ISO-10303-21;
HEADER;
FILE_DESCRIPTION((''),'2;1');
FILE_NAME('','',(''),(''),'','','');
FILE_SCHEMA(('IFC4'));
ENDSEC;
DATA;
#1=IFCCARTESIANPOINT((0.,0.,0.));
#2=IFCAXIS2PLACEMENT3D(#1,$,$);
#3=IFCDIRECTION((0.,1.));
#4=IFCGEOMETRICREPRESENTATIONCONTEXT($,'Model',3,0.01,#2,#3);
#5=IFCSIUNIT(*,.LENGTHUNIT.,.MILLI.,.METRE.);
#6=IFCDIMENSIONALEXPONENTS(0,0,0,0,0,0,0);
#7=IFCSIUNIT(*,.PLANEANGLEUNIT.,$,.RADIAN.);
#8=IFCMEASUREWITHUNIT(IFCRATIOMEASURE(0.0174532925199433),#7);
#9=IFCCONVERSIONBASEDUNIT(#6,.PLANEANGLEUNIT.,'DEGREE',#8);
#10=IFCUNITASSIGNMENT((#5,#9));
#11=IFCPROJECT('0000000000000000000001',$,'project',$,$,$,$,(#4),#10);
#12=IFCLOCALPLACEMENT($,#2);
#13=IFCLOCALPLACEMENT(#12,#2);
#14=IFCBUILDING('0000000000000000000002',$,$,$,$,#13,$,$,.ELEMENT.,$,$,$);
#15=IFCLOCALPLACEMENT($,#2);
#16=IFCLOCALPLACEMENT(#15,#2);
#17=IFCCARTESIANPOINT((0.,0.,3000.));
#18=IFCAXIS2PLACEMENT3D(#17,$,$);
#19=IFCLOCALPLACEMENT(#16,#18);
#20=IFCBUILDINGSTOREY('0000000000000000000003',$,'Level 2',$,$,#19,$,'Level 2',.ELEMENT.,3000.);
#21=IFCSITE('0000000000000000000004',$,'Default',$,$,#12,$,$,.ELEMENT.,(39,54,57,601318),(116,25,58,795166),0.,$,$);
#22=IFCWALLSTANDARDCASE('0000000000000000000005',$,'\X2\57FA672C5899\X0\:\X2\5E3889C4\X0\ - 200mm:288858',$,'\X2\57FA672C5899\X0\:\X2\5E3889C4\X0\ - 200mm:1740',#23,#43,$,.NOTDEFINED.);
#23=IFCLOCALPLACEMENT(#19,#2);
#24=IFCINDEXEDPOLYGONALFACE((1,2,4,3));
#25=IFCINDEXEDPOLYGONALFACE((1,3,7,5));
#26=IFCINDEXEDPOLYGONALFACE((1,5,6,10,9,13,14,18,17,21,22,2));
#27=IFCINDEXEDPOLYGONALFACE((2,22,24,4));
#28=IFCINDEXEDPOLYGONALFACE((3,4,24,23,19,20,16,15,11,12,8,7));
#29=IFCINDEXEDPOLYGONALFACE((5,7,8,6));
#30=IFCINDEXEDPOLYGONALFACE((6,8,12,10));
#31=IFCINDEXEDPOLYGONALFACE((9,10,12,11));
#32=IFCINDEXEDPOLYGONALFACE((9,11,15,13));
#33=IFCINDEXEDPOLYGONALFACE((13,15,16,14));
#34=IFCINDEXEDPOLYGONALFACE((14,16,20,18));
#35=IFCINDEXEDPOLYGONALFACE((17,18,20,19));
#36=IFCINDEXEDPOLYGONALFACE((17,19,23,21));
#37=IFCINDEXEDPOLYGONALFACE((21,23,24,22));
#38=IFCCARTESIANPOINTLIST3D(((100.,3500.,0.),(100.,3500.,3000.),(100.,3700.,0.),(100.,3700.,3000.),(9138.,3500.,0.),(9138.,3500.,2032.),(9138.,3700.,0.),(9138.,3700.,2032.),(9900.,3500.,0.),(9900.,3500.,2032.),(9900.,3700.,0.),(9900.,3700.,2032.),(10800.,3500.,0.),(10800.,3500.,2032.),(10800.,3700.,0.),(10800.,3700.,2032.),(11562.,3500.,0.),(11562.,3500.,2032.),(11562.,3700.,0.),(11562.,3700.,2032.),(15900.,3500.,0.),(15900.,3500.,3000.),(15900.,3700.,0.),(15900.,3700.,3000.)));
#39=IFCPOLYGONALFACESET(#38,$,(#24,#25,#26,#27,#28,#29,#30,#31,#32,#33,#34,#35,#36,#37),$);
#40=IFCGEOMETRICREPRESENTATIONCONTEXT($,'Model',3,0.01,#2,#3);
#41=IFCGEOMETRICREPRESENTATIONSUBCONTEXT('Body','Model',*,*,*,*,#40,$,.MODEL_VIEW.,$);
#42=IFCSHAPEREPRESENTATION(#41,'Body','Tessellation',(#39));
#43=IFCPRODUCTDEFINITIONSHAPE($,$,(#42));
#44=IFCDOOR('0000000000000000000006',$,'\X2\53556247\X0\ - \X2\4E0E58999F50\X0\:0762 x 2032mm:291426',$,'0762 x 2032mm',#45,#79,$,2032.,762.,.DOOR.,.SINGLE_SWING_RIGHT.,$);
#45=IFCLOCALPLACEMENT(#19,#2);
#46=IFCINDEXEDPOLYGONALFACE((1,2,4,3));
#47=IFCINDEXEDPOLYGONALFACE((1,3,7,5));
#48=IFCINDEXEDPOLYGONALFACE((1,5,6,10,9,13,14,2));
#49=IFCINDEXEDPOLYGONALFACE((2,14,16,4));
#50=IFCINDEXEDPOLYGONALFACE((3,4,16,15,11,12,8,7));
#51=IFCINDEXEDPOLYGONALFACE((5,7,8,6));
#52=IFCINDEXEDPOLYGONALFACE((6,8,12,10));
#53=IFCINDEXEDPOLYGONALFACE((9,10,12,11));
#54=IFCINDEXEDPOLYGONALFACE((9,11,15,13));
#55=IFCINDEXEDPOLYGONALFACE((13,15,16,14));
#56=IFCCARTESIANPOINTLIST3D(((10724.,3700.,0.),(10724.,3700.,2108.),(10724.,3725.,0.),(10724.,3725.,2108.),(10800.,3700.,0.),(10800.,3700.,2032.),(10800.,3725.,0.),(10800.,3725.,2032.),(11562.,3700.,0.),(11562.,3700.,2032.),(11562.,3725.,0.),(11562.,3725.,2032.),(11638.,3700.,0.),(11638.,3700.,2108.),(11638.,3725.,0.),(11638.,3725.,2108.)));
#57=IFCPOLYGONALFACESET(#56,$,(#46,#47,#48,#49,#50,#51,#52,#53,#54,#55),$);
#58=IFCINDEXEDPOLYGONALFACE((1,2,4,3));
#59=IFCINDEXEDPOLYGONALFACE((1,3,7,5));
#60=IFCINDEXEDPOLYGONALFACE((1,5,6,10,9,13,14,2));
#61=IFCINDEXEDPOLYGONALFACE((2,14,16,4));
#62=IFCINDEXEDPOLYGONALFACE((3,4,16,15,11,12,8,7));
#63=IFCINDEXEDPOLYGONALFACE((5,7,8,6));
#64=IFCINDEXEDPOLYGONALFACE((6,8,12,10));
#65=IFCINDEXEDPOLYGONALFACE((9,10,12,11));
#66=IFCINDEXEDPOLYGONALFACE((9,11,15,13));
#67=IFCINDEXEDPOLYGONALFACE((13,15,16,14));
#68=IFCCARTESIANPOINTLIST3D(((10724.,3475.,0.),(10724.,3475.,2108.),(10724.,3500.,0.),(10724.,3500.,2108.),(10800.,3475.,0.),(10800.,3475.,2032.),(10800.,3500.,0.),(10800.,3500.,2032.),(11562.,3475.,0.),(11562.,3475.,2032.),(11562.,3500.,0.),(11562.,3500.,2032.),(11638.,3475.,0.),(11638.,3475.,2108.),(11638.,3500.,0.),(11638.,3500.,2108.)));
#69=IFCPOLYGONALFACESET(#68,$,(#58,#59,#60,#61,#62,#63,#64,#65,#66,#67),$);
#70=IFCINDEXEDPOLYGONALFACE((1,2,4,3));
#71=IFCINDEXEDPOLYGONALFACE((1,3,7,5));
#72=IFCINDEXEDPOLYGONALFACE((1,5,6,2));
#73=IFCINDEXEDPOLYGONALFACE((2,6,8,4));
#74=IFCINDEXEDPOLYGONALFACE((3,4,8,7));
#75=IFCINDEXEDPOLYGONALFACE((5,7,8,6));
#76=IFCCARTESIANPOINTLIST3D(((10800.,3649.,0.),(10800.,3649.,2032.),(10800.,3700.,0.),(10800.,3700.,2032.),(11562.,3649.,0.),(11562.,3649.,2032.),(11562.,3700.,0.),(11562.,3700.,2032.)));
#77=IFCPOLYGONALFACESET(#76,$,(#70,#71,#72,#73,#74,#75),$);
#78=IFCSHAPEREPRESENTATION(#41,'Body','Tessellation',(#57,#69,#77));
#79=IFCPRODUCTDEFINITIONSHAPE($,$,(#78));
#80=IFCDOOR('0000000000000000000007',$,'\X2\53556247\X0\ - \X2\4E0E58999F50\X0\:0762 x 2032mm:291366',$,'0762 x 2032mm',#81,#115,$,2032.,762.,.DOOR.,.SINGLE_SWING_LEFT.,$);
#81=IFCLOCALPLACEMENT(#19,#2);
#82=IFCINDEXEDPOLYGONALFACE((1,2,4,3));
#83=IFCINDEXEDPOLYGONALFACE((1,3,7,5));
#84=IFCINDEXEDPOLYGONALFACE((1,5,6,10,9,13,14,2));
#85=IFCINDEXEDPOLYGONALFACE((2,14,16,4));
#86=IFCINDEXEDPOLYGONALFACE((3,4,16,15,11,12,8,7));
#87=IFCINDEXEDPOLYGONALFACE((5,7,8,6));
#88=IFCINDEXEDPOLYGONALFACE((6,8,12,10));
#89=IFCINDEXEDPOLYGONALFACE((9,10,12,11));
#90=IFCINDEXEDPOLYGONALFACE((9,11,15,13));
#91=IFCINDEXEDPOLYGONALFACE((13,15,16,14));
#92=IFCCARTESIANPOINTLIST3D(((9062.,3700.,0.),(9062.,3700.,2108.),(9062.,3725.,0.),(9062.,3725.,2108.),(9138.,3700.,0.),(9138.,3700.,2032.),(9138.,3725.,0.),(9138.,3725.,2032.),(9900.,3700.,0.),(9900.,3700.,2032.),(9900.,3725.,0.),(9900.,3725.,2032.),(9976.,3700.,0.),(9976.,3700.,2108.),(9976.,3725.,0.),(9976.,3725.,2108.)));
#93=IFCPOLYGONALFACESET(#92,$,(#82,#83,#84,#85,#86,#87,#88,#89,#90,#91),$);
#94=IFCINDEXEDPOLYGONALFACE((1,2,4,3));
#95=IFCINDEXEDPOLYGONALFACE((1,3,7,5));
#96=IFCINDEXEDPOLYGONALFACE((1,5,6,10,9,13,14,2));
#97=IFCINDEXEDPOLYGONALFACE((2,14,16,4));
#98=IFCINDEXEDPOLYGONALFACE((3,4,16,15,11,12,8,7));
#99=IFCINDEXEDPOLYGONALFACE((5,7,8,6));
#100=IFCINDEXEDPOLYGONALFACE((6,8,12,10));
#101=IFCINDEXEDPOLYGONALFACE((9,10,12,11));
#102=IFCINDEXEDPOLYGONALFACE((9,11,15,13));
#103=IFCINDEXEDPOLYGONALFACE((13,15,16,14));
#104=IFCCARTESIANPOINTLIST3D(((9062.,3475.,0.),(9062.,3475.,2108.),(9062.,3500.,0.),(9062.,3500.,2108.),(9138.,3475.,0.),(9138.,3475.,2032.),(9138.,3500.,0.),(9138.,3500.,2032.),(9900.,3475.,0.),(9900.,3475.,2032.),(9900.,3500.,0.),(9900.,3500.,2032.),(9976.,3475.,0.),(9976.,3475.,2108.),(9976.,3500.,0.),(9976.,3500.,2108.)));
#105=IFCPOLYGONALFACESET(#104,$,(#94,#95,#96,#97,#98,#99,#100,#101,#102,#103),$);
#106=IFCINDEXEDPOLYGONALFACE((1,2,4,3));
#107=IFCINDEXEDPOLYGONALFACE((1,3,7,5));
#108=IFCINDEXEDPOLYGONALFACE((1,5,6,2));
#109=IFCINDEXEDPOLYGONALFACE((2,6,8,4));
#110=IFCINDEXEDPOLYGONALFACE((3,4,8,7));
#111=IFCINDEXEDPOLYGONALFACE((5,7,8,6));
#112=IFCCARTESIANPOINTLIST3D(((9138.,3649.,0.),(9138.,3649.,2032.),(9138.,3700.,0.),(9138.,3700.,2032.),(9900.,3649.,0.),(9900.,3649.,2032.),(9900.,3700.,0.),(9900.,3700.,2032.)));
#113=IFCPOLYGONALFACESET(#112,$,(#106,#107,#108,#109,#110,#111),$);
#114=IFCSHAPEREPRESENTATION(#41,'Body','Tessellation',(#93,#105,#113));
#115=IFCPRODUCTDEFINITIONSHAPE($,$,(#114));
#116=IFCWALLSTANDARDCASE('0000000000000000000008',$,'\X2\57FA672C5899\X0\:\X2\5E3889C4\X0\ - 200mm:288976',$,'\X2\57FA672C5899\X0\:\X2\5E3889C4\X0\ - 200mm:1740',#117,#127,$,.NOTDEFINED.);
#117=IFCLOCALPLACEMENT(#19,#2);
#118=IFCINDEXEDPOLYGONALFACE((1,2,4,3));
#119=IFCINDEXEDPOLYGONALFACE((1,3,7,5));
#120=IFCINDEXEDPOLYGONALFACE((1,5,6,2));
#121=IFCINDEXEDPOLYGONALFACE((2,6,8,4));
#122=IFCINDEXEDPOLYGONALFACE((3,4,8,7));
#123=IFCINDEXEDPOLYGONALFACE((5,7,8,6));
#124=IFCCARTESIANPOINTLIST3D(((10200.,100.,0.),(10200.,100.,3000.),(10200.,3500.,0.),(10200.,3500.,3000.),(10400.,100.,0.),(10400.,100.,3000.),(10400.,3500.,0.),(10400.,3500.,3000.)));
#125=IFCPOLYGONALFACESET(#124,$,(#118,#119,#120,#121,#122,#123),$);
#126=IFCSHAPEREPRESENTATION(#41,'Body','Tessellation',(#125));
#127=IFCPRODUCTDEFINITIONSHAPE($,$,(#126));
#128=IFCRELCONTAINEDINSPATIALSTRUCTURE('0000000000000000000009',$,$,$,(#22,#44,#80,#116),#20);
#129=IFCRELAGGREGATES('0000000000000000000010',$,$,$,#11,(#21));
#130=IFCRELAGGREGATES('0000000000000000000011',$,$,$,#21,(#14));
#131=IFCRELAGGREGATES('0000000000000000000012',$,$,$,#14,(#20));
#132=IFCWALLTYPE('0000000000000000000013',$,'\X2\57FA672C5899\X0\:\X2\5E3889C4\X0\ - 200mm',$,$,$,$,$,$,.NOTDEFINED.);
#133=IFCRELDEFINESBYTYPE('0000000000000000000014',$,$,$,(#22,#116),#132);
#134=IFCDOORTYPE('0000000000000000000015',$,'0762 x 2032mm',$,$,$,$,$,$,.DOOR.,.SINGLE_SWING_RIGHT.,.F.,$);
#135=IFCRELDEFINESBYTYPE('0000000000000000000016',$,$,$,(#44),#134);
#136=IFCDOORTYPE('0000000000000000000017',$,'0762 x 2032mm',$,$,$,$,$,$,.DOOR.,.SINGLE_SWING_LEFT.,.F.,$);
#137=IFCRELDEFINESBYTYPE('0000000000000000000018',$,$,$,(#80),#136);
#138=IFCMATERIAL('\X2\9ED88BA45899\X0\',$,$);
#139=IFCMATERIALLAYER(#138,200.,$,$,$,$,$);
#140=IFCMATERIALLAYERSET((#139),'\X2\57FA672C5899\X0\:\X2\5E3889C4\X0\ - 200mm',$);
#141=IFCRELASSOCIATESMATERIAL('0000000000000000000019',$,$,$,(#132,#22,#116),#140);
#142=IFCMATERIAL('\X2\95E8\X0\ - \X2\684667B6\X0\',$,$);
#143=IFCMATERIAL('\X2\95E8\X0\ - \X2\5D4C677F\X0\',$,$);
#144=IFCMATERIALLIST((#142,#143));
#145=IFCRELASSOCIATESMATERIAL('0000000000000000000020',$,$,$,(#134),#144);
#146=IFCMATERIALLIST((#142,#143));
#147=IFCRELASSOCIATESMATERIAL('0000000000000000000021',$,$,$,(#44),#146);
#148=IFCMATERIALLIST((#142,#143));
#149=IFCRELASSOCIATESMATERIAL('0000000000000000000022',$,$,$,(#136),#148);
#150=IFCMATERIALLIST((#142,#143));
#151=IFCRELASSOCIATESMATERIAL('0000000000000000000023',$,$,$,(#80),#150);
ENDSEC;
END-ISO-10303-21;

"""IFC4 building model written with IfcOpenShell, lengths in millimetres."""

from ifc_helpers import new_model, entity, si_unit, converted_unit, direction, frame, frame_2d, origin, place, context, subcontext, project, spatial, polyline, rectangle, outline, extrude, source, transform, mapped, material, material_list, layer, layer_set, layer_usage, type_object, type_shapes, element, fill, save


model = new_model("IFC4")

# Units and contexts
model_context_1 = context("Model", 3, precision=0.01, world=origin(), true_north=direction((0.0, 1.0)))
model_context_2 = context("Model", 3, precision=0.01, world=origin(), true_north=direction((0.0, 1.0)))
body_context = subcontext(model_context_2, "Body", "Model", "MODEL_VIEW")
ifc_project = project(units=[si_unit("LENGTHUNIT", "METRE", prefix="MILLI"), converted_unit("PLANEANGLEUNIT", "DEGREE", entity("IfcRatioMeasure", 0.0174532925199433), si_unit("PLANEANGLEUNIT", "RADIAN"), dimensions=[0, 0, 0, 0, 0, 0, 0])], contexts=[model_context_1])

# Site, building, storey
site_placement = place(None, origin())
site = spatial("IfcSite", under=ifc_project, at=site_placement, Name="Default", CompositionType="ELEMENT", RefLatitude=(39, 54, 57, 601318), RefLongitude=(116, 25, 58, 795166), RefElevation=0.0)
building_placement = place(site_placement, origin())
building = spatial("IfcBuilding", under=site, at=building_placement, CompositionType="ELEMENT")
placement_1 = place(None, origin())
placement_2 = place(placement_1, origin())
storey_placement = place(placement_2, frame((0.0, 0.0, 3000.0)))
storey = spatial("IfcBuildingStorey", under=building, at=storey_placement, Name="Level 2", LongName="Level 2", CompositionType="ELEMENT", Elevation=3000.0)

# Shared definitions
ifc_material_1 = material(Name="默认墙")
ifc_layer = layer(ifc_material_1, 200.0)
ifc_layer_set = layer_set([ifc_layer], Name="基本墙:常规 - 200mm")
wall_type = type_object("IfcWallType", Name="基本墙:常规 - 200mm", PredefinedType="NOTDEFINED", material=ifc_layer_set)

# Shared definitions
ifc_material_2 = material(Name="门 - 框架")
ifc_material_3 = material(Name="门 - 嵌板")
ifc_material_list_1 = material_list([ifc_material_2, ifc_material_3])
door_type_1 = type_object("IfcDoorType", Name="0762 x 2032mm", OperationType="SINGLE_SWING_RIGHT", ParameterTakesPrecedence=False, PredefinedType="DOOR", material=ifc_material_list_1)
shared_shape_1 = source(origin(), body_context, "Body", "SweptSolid", [
    extrude(outline(polyline([(-457.0, -1073.0), (457.0, -1073.0), (457.0, 1035.0), (381.0, 1035.0), (381.0, -997.0), (-381.0, -997.0), (-381.0, 1035.0), (-457.0, 1035.0), (-457.0, -1073.0)])), frame((381.0, 200.0, 1035.0), z_axis=(0.0, 1.0, 0.0), x_axis=(1.0, 0.0, 0.0)), (0.0, 0.0, 1.0), 25.0),
    extrude(outline(polyline([(-1073.0, -457.0), (1035.0, -457.0), (1035.0, -381.0), (-997.0, -381.0), (-997.0, 381.0), (1035.0, 381.0), (1035.0, 457.0), (-1073.0, 457.0), (-1073.0, -457.0)])), frame((381.0, -25.0, 1035.0), z_axis=(0.0, 1.0, 0.0), x_axis=(0.0, 0.0, -1.0)), (0.0, 0.0, 1.0), 25.0),
    extrude(rectangle(XDim=51.0, YDim=762.0, at=frame_2d((0.0, 0.0), x_axis=(1.0, 0.0))), frame((381.0, 174.5, 0.0), z_axis=(0.0, 0.0, 1.0), x_axis=(0.0, 1.0, 0.0)), (0.0, 0.0, 1.0), 2032.0),
])
type_shapes(door_type_1, [shared_shape_1])

# Wall, openings, doors
ifc_layer_usage_1 = layer_usage(ifc_layer_set, "AXIS2", "NEGATIVE", 100.0)
wall_1_placement = place(storey_placement, frame((15900.0, 3600.0, 0.0), z_axis=(0.0, 0.0, 1.0), x_axis=(-1.0, 0.0, 0.0)))
wall_1 = element("IfcWallStandardCase", 1, at=wall_1_placement, inside=storey, type_object=wall_type, material=ifc_layer_usage_1, Name="基本墙:常规 - 200mm:288858", ObjectType="基本墙:常规 - 200mm:1740", PredefinedType="NOTDEFINED", context=body_context, shape_type="SweptSolid", body=[
    extrude(rectangle(XDim=15800.0, YDim=200.0, at=frame_2d((7900.0, 0.0), x_axis=(-1.0, 0.0))), origin(), (0.0, 0.0, 1.0), 3000.0),
])
opening_1_placement = place(wall_1_placement, frame((6762.0, 100.0, 0.0)))
opening_1 = element("IfcOpeningElement", 2, at=opening_1_placement, cuts=wall_1, ObjectType="Opening", PredefinedType="OPENING", context=body_context, shape_type="SweptSolid", body=[
    extrude(rectangle(XDim=762.0, YDim=2032.0, at=frame_2d((1016.0, 381.0), x_axis=(0.0, -1.0))), frame((0.0, 0.0, 0.0), z_axis=(0.0, -1.0, 0.0), x_axis=(0.0, 0.0, 1.0)), (0.0, 0.0, 1.0), 200.0),
])
opening_2_placement = place(wall_1_placement, frame((5100.0, 100.0, 0.0)))
opening_2 = element("IfcOpeningElement", 3, at=opening_2_placement, cuts=wall_1, ObjectType="Opening", PredefinedType="OPENING", context=body_context, shape_type="SweptSolid", body=[
    extrude(rectangle(XDim=762.0, YDim=2032.0, at=frame_2d((1016.0, 381.0), x_axis=(0.0, 1.0))), frame((0.0, 0.0, 0.0), z_axis=(0.0, -1.0, 0.0), x_axis=(0.0, 0.0, 1.0)), (0.0, 0.0, 1.0), 200.0),
])
ifc_material_list_2 = material_list([ifc_material_2, ifc_material_3])
door_1_placement = place(opening_2_placement, frame((0.0, 0.0, 0.0), z_axis=(0.0, 0.0, 1.0), x_axis=(-1.0, 0.0, 0.0)))
door_1 = element("IfcDoor", 4, at=door_1_placement, inside=storey, type_object=door_type_1, material=ifc_material_list_2, Name="单扇 - 与墙齐:0762 x 2032mm:291426", ObjectType="0762 x 2032mm", OperationType="SINGLE_SWING_RIGHT", OverallHeight=2032.0, OverallWidth=762.0, PredefinedType="DOOR", context=body_context, shape_type="MappedRepresentation", body=[
    mapped(shared_shape_1, transform((0.0, 0.0, 0.0), scale=1.0)),
])
fill(opening_2, door_1)
ifc_material_list_3 = material_list([ifc_material_2, ifc_material_3])
ifc_material_list_4 = material_list([ifc_material_2, ifc_material_3])
door_type_2 = type_object("IfcDoorType", Name="0762 x 2032mm", OperationType="SINGLE_SWING_LEFT", ParameterTakesPrecedence=False, PredefinedType="DOOR", material=ifc_material_list_4)
shared_shape_2 = source(origin(), body_context, "Body", "SweptSolid", [
    extrude(outline(polyline([(-457.0, -1073.0), (457.0, -1073.0), (457.0, 1035.0), (381.0, 1035.0), (381.0, -997.0), (-381.0, -997.0), (-381.0, 1035.0), (-457.0, 1035.0), (-457.0, -1073.0)])), frame((381.0, 225.0, 1035.0), z_axis=(0.0, -1.0, 0.0), x_axis=(-1.0, 0.0, 0.0)), (0.0, 0.0, 1.0), 25.0),
    extrude(outline(polyline([(-1073.0, -457.0), (1035.0, -457.0), (1035.0, -381.0), (-997.0, -381.0), (-997.0, 381.0), (1035.0, 381.0), (1035.0, 457.0), (-1073.0, 457.0), (-1073.0, -457.0)])), frame((381.0, 0.0, 1035.0), z_axis=(0.0, -1.0, 0.0), x_axis=(0.0, 0.0, -1.0)), (0.0, 0.0, 1.0), 25.0),
    extrude(rectangle(XDim=762.0, YDim=51.0, at=frame_2d((0.0, 0.0), x_axis=(1.0, 0.0))), frame((381.0, 174.5, 0.0)), (0.0, 0.0, 1.0), 2032.0),
])
type_shapes(door_type_2, [shared_shape_2])
door_2_placement = place(opening_1_placement, frame((0.0, 0.0, 0.0), z_axis=(0.0, 0.0, 1.0), x_axis=(-1.0, 0.0, 0.0)))
door_2 = element("IfcDoor", 5, at=door_2_placement, inside=storey, type_object=door_type_2, material=ifc_material_list_3, Name="单扇 - 与墙齐:0762 x 2032mm:291366", ObjectType="0762 x 2032mm", OperationType="SINGLE_SWING_LEFT", OverallHeight=2032.0, OverallWidth=762.0, PredefinedType="DOOR", context=body_context, shape_type="MappedRepresentation", body=[
    mapped(shared_shape_2, transform((0.0, 0.0, 0.0), scale=1.0)),
])
fill(opening_1, door_2)

# Wall
ifc_layer_usage_2 = layer_usage(ifc_layer_set, "AXIS2", "NEGATIVE", 100.0)
wall_2_placement = place(storey_placement, frame((10300.0, 3500.0, 0.0), z_axis=(0.0, 0.0, 1.0), x_axis=(0.0, -1.0, 0.0)))
element("IfcWallStandardCase", 6, at=wall_2_placement, inside=storey, type_object=wall_type, material=ifc_layer_usage_2, Name="基本墙:常规 - 200mm:288976", ObjectType="基本墙:常规 - 200mm:1740", PredefinedType="NOTDEFINED", context=body_context, shape_type="SweptSolid", body=[
    extrude(rectangle(XDim=3400.0, YDim=200.0, at=frame_2d((1700.0, 0.0), x_axis=(-1.0, 0.0))), origin(), (0.0, 0.0, 1.0), 3000.0),
])

save(model, "model.ifc")
